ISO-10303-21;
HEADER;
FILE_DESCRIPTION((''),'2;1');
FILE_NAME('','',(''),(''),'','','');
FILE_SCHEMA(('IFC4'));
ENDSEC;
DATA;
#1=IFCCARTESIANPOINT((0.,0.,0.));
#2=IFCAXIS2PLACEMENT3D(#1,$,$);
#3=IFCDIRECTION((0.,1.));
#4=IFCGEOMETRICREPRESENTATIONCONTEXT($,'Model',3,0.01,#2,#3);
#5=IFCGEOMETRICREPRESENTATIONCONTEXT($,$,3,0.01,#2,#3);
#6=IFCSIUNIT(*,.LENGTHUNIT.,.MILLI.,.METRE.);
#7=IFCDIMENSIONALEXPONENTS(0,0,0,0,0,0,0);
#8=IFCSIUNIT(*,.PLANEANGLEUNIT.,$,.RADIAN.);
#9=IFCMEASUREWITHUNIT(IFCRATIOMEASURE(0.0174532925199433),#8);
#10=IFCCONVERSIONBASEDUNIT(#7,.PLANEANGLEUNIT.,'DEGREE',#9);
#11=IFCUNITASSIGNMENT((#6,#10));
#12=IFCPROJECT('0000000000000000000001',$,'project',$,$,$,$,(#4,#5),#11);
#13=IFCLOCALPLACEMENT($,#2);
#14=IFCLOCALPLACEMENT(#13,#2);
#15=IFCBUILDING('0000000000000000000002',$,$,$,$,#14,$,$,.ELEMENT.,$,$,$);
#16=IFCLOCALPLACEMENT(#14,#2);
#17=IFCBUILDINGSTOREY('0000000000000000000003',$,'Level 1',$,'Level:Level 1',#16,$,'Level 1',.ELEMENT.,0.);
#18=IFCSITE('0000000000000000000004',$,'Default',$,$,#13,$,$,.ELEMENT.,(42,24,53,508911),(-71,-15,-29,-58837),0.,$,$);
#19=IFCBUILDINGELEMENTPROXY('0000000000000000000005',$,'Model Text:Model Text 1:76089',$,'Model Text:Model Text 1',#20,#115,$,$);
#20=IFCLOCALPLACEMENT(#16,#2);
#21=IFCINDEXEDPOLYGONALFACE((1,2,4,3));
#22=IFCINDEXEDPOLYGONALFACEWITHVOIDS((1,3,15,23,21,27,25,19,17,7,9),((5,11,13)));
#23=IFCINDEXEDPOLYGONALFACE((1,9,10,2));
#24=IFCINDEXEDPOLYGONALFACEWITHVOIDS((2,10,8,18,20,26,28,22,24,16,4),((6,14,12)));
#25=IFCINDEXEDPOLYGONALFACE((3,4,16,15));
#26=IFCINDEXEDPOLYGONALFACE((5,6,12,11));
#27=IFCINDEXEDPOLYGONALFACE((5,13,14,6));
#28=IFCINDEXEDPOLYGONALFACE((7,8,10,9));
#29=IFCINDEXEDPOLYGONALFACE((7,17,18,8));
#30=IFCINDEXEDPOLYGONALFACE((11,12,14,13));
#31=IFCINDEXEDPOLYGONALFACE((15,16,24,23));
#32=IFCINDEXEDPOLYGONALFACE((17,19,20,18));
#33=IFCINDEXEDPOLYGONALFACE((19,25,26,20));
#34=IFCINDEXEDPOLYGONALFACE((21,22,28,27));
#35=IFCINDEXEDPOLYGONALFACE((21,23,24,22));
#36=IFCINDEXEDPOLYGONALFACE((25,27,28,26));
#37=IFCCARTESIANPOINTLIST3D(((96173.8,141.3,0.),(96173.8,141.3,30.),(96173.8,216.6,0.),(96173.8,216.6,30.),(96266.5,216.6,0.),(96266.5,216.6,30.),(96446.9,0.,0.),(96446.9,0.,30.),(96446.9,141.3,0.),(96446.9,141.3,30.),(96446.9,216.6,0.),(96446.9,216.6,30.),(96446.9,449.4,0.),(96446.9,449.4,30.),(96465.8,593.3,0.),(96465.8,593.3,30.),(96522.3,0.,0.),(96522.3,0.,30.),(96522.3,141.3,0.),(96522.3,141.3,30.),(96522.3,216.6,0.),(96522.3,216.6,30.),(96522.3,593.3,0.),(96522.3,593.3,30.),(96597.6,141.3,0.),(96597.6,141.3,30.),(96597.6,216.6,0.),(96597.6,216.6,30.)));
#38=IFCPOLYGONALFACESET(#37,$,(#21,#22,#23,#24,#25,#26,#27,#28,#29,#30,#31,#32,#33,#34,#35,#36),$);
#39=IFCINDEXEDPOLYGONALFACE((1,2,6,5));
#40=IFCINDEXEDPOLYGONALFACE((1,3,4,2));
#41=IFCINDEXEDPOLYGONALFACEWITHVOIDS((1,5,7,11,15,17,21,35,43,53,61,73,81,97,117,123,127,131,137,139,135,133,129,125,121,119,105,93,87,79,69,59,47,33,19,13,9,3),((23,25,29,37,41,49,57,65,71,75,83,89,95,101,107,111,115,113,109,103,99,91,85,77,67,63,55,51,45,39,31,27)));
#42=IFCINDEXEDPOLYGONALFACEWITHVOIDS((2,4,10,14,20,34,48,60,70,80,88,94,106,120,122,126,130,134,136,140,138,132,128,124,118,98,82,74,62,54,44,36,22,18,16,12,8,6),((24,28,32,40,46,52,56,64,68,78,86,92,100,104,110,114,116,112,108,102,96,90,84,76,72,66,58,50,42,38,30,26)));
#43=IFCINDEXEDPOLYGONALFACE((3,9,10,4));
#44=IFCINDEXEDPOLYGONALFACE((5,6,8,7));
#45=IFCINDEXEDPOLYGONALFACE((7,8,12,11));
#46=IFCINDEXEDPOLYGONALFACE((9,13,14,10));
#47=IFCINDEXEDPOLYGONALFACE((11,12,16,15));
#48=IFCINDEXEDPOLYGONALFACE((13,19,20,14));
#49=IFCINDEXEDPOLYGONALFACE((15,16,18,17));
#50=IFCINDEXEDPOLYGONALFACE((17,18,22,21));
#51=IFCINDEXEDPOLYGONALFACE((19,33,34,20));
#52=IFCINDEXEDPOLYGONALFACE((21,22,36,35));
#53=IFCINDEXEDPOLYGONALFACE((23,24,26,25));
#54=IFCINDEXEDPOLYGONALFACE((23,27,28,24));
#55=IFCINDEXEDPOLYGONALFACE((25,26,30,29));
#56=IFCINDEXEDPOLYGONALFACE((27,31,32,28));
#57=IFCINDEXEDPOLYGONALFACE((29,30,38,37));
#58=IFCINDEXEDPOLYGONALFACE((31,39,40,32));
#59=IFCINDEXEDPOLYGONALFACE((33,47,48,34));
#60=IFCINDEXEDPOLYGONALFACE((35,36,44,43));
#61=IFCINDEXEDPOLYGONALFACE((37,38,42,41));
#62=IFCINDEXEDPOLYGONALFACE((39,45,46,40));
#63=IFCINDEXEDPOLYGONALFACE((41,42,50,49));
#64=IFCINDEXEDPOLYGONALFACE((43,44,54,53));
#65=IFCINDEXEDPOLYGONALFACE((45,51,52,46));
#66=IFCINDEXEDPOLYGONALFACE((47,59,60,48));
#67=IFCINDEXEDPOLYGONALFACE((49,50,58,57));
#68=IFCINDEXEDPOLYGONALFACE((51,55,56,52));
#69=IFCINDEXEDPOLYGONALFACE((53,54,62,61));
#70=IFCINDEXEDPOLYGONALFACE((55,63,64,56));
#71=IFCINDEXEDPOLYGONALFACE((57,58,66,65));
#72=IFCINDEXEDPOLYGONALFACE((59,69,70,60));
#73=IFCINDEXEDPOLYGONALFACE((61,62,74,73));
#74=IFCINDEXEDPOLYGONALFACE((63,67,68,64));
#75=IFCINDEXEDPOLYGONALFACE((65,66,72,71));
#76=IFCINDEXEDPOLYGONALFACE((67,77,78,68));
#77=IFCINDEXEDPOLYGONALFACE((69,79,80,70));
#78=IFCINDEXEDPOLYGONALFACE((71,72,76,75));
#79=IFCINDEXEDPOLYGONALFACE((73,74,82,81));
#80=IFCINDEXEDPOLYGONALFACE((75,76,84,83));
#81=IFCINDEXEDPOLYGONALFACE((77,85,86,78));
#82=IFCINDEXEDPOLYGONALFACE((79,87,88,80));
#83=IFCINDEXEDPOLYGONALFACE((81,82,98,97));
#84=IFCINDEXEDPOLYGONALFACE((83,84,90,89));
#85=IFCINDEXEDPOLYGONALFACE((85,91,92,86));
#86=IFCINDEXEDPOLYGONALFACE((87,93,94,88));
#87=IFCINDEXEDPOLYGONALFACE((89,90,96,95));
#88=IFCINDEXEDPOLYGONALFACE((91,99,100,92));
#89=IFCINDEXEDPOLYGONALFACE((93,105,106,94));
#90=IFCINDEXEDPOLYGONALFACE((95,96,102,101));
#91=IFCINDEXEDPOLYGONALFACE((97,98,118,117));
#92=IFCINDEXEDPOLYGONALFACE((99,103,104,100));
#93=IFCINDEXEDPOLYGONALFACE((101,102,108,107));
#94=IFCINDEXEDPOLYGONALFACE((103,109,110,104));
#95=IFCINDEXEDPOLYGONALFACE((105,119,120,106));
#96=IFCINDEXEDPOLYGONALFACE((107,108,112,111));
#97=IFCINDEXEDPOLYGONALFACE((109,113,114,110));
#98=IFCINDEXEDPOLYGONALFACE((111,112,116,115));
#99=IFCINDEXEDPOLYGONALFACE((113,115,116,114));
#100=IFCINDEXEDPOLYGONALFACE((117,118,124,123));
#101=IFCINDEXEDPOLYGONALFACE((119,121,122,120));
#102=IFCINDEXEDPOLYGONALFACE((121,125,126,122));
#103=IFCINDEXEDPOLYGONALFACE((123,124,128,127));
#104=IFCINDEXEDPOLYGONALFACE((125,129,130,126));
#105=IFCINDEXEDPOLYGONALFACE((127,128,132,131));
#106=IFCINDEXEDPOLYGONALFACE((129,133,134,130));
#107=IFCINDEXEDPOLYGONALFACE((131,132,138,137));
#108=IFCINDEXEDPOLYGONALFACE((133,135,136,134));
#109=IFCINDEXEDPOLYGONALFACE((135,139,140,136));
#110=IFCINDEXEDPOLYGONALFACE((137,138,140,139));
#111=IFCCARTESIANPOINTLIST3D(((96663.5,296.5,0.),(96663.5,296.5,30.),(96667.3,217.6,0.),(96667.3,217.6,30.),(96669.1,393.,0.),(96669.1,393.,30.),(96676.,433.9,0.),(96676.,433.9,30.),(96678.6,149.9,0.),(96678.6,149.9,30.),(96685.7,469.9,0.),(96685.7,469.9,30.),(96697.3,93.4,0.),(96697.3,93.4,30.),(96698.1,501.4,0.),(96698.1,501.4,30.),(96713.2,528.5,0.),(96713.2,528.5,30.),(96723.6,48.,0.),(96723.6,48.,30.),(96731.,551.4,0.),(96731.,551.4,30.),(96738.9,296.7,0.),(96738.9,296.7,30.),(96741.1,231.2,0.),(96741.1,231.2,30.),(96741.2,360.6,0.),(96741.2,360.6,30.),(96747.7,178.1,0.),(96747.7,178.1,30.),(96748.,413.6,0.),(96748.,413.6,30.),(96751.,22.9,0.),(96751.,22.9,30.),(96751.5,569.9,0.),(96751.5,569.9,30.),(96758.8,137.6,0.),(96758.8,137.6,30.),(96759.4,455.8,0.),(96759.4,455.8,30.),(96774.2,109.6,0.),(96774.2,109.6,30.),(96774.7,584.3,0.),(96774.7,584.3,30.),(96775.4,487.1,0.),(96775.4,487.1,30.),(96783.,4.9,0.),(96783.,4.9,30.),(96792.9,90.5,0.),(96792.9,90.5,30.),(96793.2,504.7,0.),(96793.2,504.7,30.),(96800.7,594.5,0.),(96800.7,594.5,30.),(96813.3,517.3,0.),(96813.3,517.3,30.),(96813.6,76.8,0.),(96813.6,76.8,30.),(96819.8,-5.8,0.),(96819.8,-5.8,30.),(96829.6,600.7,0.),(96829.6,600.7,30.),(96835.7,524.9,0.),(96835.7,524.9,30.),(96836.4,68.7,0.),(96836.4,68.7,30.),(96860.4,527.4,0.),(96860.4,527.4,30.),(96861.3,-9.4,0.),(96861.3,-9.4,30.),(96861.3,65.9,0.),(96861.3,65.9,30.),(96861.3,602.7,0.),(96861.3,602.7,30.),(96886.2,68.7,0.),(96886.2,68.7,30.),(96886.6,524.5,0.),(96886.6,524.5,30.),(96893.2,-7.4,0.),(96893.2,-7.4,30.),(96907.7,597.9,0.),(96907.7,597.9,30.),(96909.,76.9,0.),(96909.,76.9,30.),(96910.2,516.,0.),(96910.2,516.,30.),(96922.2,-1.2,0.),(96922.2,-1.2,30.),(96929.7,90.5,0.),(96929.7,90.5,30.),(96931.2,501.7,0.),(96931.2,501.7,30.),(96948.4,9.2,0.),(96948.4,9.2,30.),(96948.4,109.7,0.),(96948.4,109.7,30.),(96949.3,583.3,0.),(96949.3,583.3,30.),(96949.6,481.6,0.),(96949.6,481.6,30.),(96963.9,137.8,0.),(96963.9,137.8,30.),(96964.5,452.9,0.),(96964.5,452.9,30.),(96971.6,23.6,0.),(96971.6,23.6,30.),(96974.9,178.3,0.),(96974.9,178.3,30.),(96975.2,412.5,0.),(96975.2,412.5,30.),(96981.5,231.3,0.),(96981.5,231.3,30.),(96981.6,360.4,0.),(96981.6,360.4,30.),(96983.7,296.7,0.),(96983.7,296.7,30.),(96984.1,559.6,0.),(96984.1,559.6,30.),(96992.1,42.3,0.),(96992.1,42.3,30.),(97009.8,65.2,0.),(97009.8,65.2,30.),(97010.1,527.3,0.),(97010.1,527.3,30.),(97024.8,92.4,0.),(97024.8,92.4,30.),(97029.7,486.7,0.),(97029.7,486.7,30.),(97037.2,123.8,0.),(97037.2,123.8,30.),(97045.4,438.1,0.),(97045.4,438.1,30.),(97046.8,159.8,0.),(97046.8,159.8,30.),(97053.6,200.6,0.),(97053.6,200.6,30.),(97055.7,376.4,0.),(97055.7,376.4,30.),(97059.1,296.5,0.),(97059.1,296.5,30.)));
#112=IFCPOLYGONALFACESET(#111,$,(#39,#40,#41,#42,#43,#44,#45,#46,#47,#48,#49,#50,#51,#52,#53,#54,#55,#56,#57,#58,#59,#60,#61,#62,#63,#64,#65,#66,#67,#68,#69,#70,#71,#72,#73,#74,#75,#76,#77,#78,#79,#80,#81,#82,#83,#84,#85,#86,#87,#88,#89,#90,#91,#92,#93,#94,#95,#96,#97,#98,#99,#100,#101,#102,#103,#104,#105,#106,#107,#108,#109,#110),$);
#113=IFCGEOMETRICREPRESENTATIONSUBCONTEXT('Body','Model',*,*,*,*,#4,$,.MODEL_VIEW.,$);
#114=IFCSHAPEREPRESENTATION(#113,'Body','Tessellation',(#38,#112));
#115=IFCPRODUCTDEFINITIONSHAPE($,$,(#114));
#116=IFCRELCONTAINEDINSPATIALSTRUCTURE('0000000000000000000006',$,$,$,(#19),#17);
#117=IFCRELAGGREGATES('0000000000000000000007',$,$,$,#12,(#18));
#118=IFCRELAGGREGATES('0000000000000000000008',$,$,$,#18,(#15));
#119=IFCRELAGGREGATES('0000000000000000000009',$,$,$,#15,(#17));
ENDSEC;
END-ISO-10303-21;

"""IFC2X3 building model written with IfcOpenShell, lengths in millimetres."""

from ifc_helpers import new_model, entity, si_unit, converted_unit, direction, frame, origin, place, context, subcontext, project, spatial, polyline, outline, extrude, element, save


model = new_model("IFC2X3")

# Units and contexts
model_context = context("Model", 3, precision=0.01, world=origin(), true_north=direction((0.0, 1.0)))
context_of_model = context(None, 3, precision=0.01, world=origin(), true_north=direction((0.0, 1.0)))
body_context = subcontext(model_context, "Body", "Model", "MODEL_VIEW")
ifc_project = project(units=[si_unit("LENGTHUNIT", "METRE", prefix="MILLI"), converted_unit("PLANEANGLEUNIT", "DEGREE", entity("IfcRatioMeasure", 0.0174532925199433), si_unit("PLANEANGLEUNIT", "RADIAN"), dimensions=[0, 0, 0, 0, 0, 0, 0])], contexts=[model_context, context_of_model])

# Site, building, storey
site_placement = place(None, origin())
site = spatial("IfcSite", under=ifc_project, at=site_placement, Name="Default", CompositionType="ELEMENT", RefLatitude=(42, 24, 53, 508911), RefLongitude=(-71, -15, -29, -58837), RefElevation=0.0)
building_placement = place(site_placement, origin())
building = spatial("IfcBuilding", under=site, at=building_placement, CompositionType="ELEMENT")
storey_placement = place(building_placement, origin())
storey = spatial("IfcBuildingStorey", under=building, at=storey_placement, Name="Level 1", ObjectType="Level:Level 1", LongName="Level 1", CompositionType="ELEMENT", Elevation=0.0)

# Building element proxy
proxy_1_placement = place(storey_placement, origin())
element("IfcBuildingElementProxy", 1, at=proxy_1_placement, inside=storey, Name="Model Text:Model Text 1:76089", ObjectType="Model Text:Model Text 1", context=body_context, shape_type="SweptSolid", body=[
    extrude(outline(polyline([(-6.8, -218.3), (68.5, -218.3), (68.5, -77.1), (143.8, -77.1), (143.8, -1.7), (68.5, -1.7), (68.5, 375.0), (12.0, 375.0), (-280.0, -1.7), (-280.0, -77.1), (-6.8, -77.1), (-6.8, -218.3)]), holes=[polyline([(-6.8, -1.7), (-187.3, -1.7), (-6.8, 231.1), (-6.8, -1.7)])]), frame((96453.8, 218.3, 0.0)), (0.0, 0.0, 1.0), 30.0),
    extrude(outline(polyline([(-10.6, -198.7), (68.3, -198.7), (136.5, -190.7), (193.9, -174.7), (240.5, -150.6), (266.9, -124.4), (286.3, -93.2), (298.8, -57.0), (304.3, -15.7), (303.8, 16.2), (299.0, 45.5), (289.9, 72.1), (276.6, 96.0), (258.9, 117.3), (236.9, 136.2), (210.4, 152.5), (179.6, 166.3), (144.1, 177.6), (103.7, 186.3), (8.2, 196.4), (-71.8, 196.7), (-134.0, 189.4), (-183.3, 176.1), (-224.7, 158.4), (-258.2, 133.9), (-283.5, 100.3), (-300.1, 59.5), (-307.1, 13.4), (-306.6, -18.4), (-301.8, -47.5), (-292.8, -74.0), (-279.6, -97.9), (-262.0, -119.2), (-240.0, -138.1), (-213.6, -154.5), (-182.8, -168.4), (-147.3, -179.8), (-106.7, -188.6), (-10.6, -198.7)]), holes=[polyline([(-7.2, -123.5), (-71.0, -118.2), (-123.6, -108.8), (-165.2, -95.4), (-195.7, -78.0), (-212.4, -59.4), (-224.1, -38.7), (-230.6, -15.9), (-231.9, 8.9), (-227.8, 35.0), (-218.1, 58.1), (-202.8, 78.4), (-182.0, 95.8), (-152.6, 109.4), (-111.7, 118.1), (-59.4, 122.0), (4.4, 121.1), (69.6, 115.8), (122.2, 106.7), (162.2, 93.7), (189.5, 77.0), (207.7, 57.4), (220.4, 36.0), (227.5, 12.8), (229.1, -12.1), (225.2, -36.8), (215.9, -59.2), (201.3, -79.3), (181.4, -97.1), (152.6, -111.2), (111.6, -120.3), (58.3, -124.4), (-7.2, -123.5)])]), frame((96862.6, 295.3, 0.0), z_axis=(0.0, 0.0, 1.0), x_axis=(0.047515, -0.998871, 0.0)), (0.0, 0.0, 1.0), 30.0),
])

save(model, "model.ifc")
